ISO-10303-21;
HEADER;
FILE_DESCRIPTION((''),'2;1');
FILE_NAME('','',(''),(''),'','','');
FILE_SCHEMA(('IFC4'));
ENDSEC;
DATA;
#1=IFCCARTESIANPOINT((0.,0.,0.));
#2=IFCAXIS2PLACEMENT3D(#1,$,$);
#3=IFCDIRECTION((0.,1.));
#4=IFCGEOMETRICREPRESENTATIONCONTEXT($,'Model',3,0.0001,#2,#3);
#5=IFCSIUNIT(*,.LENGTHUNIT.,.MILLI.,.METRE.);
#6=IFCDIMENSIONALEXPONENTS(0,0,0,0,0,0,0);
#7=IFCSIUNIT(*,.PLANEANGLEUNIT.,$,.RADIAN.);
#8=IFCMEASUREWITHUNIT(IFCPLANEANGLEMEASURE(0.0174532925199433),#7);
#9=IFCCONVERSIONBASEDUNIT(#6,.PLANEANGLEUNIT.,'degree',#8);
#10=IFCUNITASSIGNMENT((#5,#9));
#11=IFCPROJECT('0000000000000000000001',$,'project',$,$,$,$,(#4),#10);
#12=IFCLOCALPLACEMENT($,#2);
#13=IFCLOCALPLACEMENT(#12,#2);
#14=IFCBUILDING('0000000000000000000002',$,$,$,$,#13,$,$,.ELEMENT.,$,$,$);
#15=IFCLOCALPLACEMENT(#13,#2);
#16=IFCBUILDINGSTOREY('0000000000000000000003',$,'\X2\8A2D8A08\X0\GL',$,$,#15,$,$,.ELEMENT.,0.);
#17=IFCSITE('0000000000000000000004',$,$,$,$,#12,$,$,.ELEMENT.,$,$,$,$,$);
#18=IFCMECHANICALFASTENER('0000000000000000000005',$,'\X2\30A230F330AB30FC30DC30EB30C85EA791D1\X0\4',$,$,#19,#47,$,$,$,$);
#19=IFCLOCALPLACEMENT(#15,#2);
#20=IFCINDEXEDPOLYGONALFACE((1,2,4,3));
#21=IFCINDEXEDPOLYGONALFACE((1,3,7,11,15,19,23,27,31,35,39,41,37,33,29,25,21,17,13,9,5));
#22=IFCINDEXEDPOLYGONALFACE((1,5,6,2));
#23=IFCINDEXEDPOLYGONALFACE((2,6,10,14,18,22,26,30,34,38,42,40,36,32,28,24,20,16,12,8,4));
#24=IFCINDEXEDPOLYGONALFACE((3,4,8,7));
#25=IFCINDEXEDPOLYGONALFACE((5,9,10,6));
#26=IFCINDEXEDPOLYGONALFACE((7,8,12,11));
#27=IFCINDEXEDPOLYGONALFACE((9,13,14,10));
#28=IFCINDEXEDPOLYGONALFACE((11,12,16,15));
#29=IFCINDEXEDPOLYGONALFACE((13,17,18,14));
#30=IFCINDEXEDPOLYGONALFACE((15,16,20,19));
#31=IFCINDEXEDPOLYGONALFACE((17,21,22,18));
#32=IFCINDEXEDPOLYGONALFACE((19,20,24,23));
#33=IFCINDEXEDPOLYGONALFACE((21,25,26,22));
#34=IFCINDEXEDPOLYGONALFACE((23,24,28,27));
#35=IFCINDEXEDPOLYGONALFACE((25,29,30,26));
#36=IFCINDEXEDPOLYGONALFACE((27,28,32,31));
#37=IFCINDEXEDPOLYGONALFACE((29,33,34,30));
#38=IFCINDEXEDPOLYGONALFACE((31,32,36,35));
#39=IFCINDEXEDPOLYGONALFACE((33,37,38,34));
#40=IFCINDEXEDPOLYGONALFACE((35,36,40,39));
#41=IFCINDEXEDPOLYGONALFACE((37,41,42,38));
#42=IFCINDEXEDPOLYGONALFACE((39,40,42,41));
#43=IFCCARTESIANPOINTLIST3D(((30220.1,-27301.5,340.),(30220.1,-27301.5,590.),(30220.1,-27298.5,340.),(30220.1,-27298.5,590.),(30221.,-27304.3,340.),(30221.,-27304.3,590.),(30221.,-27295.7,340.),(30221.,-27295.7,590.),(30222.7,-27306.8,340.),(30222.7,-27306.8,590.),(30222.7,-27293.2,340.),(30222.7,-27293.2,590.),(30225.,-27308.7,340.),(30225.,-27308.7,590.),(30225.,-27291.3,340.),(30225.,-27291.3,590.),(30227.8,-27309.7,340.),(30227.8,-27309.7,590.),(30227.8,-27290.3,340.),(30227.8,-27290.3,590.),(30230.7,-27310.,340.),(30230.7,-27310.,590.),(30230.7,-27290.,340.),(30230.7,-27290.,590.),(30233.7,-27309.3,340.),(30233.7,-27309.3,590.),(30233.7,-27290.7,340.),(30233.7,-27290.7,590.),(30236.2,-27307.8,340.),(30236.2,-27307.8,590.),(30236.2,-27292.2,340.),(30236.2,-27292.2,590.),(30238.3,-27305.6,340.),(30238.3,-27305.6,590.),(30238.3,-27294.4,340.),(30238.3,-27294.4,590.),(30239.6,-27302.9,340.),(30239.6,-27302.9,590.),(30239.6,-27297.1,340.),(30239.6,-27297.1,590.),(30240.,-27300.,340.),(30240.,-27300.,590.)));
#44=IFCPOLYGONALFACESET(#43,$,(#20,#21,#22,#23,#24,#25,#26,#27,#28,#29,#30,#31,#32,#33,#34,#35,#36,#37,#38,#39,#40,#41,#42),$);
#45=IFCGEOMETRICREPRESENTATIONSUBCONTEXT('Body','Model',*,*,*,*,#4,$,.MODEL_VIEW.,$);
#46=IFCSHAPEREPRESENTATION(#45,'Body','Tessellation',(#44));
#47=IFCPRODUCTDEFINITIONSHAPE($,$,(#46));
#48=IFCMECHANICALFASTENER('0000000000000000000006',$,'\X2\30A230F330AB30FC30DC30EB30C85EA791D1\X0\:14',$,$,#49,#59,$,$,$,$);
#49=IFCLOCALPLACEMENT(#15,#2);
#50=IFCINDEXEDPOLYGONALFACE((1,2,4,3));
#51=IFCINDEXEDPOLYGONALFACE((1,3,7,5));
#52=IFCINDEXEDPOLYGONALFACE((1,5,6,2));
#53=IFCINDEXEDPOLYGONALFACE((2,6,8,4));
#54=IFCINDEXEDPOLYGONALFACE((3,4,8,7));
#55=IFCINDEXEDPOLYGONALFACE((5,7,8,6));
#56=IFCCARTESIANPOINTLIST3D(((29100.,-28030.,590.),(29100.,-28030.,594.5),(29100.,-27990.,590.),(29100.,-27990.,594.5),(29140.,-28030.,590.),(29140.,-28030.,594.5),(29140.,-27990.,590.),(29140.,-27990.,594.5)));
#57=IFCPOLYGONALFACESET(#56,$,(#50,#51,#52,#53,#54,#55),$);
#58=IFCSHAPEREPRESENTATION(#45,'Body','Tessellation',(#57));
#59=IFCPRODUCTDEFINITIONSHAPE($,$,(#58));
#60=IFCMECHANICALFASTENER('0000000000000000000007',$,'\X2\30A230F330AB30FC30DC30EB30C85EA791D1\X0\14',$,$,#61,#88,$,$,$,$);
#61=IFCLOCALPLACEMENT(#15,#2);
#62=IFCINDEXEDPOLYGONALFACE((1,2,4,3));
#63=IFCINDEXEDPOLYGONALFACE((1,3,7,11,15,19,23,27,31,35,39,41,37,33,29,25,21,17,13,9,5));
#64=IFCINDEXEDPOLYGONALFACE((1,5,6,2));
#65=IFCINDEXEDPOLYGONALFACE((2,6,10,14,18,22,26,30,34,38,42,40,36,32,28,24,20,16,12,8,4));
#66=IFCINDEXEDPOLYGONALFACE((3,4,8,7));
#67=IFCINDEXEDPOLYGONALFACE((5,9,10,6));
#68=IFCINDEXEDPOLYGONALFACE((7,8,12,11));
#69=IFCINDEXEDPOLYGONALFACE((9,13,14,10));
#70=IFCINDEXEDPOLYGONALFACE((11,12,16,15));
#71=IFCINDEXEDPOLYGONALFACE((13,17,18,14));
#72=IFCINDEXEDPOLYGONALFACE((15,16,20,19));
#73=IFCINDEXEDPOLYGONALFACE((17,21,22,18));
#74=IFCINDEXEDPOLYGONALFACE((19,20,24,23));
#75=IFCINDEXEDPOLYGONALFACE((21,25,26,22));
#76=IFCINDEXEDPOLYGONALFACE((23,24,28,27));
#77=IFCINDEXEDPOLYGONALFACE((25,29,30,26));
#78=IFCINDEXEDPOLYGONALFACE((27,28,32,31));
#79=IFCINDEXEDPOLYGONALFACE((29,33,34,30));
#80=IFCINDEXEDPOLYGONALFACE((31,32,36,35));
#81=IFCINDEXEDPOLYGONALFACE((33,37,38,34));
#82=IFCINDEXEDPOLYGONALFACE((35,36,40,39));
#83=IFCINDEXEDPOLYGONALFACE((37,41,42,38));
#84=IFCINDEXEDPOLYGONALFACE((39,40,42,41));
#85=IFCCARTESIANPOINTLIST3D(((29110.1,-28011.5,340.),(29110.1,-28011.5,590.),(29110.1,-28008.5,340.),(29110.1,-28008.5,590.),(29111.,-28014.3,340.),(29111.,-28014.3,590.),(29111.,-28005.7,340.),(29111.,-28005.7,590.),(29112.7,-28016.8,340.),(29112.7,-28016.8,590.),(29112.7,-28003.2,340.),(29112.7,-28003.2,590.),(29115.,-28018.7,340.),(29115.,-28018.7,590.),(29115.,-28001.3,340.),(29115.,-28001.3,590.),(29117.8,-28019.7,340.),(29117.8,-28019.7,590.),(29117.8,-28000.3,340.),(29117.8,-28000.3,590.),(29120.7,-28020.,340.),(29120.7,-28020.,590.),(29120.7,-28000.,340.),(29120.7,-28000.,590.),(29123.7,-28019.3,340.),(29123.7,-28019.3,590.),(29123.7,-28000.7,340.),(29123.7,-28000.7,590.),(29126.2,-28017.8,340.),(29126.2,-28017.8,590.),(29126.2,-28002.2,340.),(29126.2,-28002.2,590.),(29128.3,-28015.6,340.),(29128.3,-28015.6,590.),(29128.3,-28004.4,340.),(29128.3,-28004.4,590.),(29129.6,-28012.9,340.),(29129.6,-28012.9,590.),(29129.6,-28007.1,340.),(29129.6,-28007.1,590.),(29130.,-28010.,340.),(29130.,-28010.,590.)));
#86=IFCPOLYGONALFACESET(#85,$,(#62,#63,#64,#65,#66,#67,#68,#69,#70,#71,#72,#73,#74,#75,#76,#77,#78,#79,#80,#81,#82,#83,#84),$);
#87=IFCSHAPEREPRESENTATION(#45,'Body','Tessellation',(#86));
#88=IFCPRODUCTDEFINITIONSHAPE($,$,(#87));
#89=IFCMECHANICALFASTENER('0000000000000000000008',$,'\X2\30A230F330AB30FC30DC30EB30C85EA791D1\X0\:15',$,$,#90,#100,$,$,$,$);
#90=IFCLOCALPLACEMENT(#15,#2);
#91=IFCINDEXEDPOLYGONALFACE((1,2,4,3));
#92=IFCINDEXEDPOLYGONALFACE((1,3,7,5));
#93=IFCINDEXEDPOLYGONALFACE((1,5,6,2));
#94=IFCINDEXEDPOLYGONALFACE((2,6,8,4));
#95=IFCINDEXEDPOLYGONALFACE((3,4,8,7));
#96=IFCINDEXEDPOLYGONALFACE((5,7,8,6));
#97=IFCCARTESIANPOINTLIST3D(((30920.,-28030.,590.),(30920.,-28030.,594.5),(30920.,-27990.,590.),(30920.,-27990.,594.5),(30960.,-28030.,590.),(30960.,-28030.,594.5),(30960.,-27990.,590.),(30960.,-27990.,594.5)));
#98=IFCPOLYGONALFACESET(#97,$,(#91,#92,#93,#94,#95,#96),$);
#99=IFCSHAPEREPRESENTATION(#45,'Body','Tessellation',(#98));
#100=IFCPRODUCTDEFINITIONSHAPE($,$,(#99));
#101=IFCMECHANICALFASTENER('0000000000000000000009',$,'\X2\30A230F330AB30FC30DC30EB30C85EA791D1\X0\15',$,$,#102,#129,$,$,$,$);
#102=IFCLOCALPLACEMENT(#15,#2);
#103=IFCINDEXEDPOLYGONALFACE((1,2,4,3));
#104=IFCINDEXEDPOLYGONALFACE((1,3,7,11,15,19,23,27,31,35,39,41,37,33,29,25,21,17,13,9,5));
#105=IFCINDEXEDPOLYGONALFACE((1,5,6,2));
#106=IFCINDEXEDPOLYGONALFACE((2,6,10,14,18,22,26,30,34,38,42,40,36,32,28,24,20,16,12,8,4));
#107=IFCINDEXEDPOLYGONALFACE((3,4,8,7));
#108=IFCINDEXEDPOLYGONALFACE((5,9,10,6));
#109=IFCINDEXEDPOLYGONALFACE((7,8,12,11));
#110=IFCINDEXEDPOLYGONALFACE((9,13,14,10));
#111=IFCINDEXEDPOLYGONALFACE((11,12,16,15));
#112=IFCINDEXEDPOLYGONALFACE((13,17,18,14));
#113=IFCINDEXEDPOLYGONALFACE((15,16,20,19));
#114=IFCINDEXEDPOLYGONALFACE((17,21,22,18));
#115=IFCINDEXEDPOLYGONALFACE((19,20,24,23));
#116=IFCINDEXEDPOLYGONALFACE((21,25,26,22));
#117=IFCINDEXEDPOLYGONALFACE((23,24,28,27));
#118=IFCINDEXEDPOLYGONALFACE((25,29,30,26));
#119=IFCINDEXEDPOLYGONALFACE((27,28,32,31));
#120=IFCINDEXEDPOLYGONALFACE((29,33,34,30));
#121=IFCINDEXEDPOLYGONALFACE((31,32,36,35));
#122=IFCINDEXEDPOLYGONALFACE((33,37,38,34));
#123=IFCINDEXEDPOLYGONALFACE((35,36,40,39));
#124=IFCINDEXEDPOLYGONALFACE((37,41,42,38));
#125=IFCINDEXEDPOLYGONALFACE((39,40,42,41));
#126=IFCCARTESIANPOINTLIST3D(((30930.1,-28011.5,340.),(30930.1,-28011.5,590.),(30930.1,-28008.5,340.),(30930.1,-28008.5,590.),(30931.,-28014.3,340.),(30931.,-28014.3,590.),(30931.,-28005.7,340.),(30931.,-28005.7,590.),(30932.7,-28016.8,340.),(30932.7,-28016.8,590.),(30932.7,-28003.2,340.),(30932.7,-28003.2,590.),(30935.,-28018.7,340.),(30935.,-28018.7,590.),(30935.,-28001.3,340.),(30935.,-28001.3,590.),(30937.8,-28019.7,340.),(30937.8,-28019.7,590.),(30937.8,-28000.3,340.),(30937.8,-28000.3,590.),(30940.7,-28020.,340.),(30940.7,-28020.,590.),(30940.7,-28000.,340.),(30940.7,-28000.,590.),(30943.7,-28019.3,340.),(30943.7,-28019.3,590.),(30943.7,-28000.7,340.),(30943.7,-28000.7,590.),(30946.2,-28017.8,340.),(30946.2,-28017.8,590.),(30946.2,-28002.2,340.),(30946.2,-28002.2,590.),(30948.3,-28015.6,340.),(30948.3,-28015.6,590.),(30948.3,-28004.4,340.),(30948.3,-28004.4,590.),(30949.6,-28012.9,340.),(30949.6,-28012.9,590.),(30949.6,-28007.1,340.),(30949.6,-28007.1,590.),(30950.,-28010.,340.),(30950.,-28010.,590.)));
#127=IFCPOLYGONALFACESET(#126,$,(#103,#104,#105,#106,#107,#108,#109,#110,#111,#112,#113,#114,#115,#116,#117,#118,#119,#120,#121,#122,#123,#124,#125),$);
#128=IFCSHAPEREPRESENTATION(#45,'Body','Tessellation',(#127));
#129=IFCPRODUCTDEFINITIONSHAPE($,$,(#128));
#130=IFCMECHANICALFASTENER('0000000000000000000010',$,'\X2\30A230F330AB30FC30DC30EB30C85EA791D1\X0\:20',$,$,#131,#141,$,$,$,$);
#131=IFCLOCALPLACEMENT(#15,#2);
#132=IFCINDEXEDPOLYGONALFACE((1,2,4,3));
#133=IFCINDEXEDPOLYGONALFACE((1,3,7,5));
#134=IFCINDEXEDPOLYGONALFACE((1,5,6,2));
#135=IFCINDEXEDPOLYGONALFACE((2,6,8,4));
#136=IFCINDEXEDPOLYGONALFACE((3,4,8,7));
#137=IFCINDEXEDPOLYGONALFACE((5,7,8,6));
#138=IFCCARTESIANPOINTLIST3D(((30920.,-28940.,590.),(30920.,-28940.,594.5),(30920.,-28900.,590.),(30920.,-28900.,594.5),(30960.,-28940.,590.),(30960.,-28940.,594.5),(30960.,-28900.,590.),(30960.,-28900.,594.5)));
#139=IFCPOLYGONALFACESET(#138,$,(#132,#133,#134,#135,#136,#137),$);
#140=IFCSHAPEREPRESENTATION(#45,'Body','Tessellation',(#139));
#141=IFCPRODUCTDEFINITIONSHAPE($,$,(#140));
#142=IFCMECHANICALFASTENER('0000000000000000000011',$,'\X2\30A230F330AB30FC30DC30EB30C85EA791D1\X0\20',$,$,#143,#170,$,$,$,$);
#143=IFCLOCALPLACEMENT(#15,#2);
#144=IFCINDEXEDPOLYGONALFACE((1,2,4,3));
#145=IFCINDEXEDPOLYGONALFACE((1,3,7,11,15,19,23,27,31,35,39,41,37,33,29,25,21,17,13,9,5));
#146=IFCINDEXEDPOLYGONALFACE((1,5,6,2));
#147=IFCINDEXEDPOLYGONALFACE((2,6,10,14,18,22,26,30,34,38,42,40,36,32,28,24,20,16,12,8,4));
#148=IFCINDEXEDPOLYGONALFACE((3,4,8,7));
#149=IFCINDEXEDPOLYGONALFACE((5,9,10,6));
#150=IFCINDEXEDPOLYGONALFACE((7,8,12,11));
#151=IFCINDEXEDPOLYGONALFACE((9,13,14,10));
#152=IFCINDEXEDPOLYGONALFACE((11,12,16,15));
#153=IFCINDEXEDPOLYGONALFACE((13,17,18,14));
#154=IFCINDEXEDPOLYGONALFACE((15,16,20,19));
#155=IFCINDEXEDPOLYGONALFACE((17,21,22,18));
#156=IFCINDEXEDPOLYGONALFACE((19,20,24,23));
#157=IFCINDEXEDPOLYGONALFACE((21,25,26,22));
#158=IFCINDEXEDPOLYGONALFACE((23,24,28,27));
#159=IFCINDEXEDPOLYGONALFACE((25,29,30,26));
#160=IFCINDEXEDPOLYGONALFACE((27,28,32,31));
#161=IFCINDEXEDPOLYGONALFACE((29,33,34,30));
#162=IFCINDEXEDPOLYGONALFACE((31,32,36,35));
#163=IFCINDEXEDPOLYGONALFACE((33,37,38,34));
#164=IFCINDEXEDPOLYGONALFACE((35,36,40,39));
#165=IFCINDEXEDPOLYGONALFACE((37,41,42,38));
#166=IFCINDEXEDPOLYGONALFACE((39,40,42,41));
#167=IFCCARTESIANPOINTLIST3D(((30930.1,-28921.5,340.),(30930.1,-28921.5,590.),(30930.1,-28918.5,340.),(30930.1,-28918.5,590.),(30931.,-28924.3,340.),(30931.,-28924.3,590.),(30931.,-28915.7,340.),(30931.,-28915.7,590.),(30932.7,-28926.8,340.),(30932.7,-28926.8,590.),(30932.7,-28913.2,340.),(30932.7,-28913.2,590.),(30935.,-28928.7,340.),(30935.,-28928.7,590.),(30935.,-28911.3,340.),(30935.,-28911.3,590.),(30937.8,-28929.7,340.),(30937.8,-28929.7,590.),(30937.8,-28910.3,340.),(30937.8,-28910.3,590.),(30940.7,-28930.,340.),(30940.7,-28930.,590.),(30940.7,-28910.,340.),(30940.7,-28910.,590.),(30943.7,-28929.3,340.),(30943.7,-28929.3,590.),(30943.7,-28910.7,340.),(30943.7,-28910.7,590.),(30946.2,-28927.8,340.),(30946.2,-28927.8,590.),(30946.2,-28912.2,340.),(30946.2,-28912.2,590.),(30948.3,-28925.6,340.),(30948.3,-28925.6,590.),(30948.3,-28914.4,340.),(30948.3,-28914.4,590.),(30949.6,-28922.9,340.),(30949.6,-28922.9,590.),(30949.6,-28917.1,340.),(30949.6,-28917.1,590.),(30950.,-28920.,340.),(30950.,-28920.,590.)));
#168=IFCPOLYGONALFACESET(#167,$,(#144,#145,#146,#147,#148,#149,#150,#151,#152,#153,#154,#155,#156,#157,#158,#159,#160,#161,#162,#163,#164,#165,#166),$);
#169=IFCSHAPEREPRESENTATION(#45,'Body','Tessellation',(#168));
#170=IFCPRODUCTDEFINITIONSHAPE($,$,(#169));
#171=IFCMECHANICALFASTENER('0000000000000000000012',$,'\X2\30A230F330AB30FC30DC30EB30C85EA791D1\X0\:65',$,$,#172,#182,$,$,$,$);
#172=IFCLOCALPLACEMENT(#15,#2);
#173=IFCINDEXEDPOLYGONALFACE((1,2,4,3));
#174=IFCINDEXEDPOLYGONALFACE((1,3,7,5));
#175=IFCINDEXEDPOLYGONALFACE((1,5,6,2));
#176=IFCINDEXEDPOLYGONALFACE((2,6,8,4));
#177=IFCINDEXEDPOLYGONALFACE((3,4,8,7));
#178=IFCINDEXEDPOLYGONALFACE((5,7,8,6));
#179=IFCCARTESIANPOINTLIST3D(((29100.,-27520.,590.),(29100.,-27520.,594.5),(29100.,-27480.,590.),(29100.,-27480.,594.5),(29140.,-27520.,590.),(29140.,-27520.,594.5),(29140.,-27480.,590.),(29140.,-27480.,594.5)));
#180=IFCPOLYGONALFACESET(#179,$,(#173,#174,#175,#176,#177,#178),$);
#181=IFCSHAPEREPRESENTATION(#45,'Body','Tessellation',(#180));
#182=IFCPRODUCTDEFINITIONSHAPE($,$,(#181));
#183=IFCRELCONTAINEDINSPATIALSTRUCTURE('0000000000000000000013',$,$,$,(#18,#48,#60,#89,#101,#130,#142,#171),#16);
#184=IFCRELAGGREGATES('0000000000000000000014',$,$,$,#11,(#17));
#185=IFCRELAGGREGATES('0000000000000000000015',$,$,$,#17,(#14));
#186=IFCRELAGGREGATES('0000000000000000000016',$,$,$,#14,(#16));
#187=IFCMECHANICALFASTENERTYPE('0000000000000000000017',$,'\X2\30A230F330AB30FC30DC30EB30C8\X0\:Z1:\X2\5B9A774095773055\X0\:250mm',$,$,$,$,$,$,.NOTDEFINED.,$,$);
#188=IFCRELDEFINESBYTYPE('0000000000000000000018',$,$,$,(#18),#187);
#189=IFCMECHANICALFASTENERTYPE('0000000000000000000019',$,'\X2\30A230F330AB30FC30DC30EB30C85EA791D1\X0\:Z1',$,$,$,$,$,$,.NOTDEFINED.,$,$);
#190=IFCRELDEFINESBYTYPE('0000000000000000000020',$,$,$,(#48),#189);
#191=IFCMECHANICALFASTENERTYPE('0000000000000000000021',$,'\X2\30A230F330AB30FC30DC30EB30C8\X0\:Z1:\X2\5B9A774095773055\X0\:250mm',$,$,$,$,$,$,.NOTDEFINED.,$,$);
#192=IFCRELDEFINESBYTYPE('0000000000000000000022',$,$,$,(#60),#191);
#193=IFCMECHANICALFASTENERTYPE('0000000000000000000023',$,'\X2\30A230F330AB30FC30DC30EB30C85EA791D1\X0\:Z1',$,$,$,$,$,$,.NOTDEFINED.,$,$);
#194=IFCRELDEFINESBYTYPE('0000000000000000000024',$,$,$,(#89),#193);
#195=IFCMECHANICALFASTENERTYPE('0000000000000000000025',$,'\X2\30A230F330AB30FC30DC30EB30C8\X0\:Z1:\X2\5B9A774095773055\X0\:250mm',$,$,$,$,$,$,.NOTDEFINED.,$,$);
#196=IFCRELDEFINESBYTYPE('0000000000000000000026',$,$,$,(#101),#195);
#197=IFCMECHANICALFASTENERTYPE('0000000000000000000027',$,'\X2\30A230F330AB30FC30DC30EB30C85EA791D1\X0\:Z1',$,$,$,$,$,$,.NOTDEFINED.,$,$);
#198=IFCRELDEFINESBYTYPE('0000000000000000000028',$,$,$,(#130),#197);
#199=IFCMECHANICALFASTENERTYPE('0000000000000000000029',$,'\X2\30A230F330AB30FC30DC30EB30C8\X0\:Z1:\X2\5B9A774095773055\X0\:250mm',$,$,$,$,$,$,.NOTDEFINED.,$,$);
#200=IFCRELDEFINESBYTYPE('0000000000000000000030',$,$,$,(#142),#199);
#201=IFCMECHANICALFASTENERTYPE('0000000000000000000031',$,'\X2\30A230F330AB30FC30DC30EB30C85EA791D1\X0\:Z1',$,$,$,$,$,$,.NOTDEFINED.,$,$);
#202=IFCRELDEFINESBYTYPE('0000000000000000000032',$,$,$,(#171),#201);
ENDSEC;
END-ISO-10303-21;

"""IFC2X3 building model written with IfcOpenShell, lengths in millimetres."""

from ifc_helpers import new_model, entity, si_unit, converted_unit, direction, frame, origin, origin_with_axes, origin_2d, place, context, subcontext, project, spatial, rectangle, circle, extrude, type_object, element, save


model = new_model("IFC2X3")

# Units and contexts
model_context = context("Model", 3, precision=0.0001, world=origin(), true_north=direction((0.0, 1.0)))
body_context = subcontext(model_context, "Body", "Model", "MODEL_VIEW")
ifc_project = project(units=[si_unit("LENGTHUNIT", "METRE", prefix="MILLI"), converted_unit("PLANEANGLEUNIT", "degree", entity("IfcPlaneAngleMeasure", 0.0174532925199433), si_unit("PLANEANGLEUNIT", "RADIAN"), dimensions=[0, 0, 0, 0, 0, 0, 0])], contexts=[model_context])

# Site, building, storey
site_placement = place(None, origin())
site = spatial("IfcSite", under=ifc_project, at=site_placement, CompositionType="ELEMENT")
building_placement = place(site_placement, origin())
building = spatial("IfcBuilding", under=site, at=building_placement, CompositionType="ELEMENT")
storey_placement = place(building_placement, origin())
storey = spatial("IfcBuildingStorey", under=building, at=storey_placement, Name="設計GL", CompositionType="ELEMENT", Elevation=0.0)

# Mechanical fasteners
mechanical_fastener_type_1 = type_object("IfcMechanicalFastenerType", Name="アンカーボルト:Z1:定着長さ:250mm")
mechanical_fastener_1_placement = place(storey_placement, frame((30230.0, -27300.0, 340.0)))
element("IfcMechanicalFastener", 1, at=mechanical_fastener_1_placement, inside=storey, type_object=mechanical_fastener_type_1, Name="アンカーボルト座金4", context=body_context, shape_type="SweptSolid", body=[
    extrude(circle(Radius=10.0, at=origin_2d()), origin_with_axes(), (0.0, 0.0, 1.0), 250.0),
])
mechanical_fastener_type_2 = type_object("IfcMechanicalFastenerType", Name="アンカーボルト座金:Z1")
mechanical_fastener_2_placement = place(storey_placement, frame((29120.0, -28010.0, 590.0)))
element("IfcMechanicalFastener", 2, at=mechanical_fastener_2_placement, inside=storey, type_object=mechanical_fastener_type_2, Name="アンカーボルト座金:14", context=body_context, shape_type="SweptSolid", body=[
    extrude(rectangle(XDim=40.0, YDim=40.0, at=origin_2d()), origin_with_axes(), (0.0, 0.0, 1.0), 4.5),
])
mechanical_fastener_type_3 = type_object("IfcMechanicalFastenerType", Name="アンカーボルト:Z1:定着長さ:250mm")
mechanical_fastener_3_placement = place(storey_placement, frame((29120.0, -28010.0, 340.0)))
element("IfcMechanicalFastener", 3, at=mechanical_fastener_3_placement, inside=storey, type_object=mechanical_fastener_type_3, Name="アンカーボルト座金14", context=body_context, shape_type="SweptSolid", body=[
    extrude(circle(Radius=10.0, at=origin_2d()), origin_with_axes(), (0.0, 0.0, 1.0), 250.0),
])
mechanical_fastener_type_4 = type_object("IfcMechanicalFastenerType", Name="アンカーボルト座金:Z1")
mechanical_fastener_4_placement = place(storey_placement, frame((30940.0, -28010.0, 590.0)))
element("IfcMechanicalFastener", 4, at=mechanical_fastener_4_placement, inside=storey, type_object=mechanical_fastener_type_4, Name="アンカーボルト座金:15", context=body_context, shape_type="SweptSolid", body=[
    extrude(rectangle(XDim=40.0, YDim=40.0, at=origin_2d()), origin_with_axes(), (0.0, 0.0, 1.0), 4.5),
])
mechanical_fastener_type_5 = type_object("IfcMechanicalFastenerType", Name="アンカーボルト:Z1:定着長さ:250mm")
mechanical_fastener_5_placement = place(storey_placement, frame((30940.0, -28010.0, 340.0)))
element("IfcMechanicalFastener", 5, at=mechanical_fastener_5_placement, inside=storey, type_object=mechanical_fastener_type_5, Name="アンカーボルト座金15", context=body_context, shape_type="SweptSolid", body=[
    extrude(circle(Radius=10.0, at=origin_2d()), origin_with_axes(), (0.0, 0.0, 1.0), 250.0),
])
mechanical_fastener_type_6 = type_object("IfcMechanicalFastenerType", Name="アンカーボルト座金:Z1")
mechanical_fastener_6_placement = place(storey_placement, frame((30940.0, -28920.0, 590.0)))
element("IfcMechanicalFastener", 6, at=mechanical_fastener_6_placement, inside=storey, type_object=mechanical_fastener_type_6, Name="アンカーボルト座金:20", context=body_context, shape_type="SweptSolid", body=[
    extrude(rectangle(XDim=40.0, YDim=40.0, at=origin_2d()), origin_with_axes(), (0.0, 0.0, 1.0), 4.5),
])
mechanical_fastener_type_7 = type_object("IfcMechanicalFastenerType", Name="アンカーボルト:Z1:定着長さ:250mm")
mechanical_fastener_7_placement = place(storey_placement, frame((30940.0, -28920.0, 340.0)))
element("IfcMechanicalFastener", 7, at=mechanical_fastener_7_placement, inside=storey, type_object=mechanical_fastener_type_7, Name="アンカーボルト座金20", context=body_context, shape_type="SweptSolid", body=[
    extrude(circle(Radius=10.0, at=origin_2d()), origin_with_axes(), (0.0, 0.0, 1.0), 250.0),
])
mechanical_fastener_type_8 = type_object("IfcMechanicalFastenerType", Name="アンカーボルト座金:Z1")
mechanical_fastener_8_placement = place(storey_placement, frame((29120.0, -27500.0, 590.0)))
element("IfcMechanicalFastener", 8, at=mechanical_fastener_8_placement, inside=storey, type_object=mechanical_fastener_type_8, Name="アンカーボルト座金:65", context=body_context, shape_type="SweptSolid", body=[
    extrude(rectangle(XDim=40.0, YDim=40.0, at=origin_2d()), origin_with_axes(), (0.0, 0.0, 1.0), 4.5),
])

save(model, "model.ifc")
